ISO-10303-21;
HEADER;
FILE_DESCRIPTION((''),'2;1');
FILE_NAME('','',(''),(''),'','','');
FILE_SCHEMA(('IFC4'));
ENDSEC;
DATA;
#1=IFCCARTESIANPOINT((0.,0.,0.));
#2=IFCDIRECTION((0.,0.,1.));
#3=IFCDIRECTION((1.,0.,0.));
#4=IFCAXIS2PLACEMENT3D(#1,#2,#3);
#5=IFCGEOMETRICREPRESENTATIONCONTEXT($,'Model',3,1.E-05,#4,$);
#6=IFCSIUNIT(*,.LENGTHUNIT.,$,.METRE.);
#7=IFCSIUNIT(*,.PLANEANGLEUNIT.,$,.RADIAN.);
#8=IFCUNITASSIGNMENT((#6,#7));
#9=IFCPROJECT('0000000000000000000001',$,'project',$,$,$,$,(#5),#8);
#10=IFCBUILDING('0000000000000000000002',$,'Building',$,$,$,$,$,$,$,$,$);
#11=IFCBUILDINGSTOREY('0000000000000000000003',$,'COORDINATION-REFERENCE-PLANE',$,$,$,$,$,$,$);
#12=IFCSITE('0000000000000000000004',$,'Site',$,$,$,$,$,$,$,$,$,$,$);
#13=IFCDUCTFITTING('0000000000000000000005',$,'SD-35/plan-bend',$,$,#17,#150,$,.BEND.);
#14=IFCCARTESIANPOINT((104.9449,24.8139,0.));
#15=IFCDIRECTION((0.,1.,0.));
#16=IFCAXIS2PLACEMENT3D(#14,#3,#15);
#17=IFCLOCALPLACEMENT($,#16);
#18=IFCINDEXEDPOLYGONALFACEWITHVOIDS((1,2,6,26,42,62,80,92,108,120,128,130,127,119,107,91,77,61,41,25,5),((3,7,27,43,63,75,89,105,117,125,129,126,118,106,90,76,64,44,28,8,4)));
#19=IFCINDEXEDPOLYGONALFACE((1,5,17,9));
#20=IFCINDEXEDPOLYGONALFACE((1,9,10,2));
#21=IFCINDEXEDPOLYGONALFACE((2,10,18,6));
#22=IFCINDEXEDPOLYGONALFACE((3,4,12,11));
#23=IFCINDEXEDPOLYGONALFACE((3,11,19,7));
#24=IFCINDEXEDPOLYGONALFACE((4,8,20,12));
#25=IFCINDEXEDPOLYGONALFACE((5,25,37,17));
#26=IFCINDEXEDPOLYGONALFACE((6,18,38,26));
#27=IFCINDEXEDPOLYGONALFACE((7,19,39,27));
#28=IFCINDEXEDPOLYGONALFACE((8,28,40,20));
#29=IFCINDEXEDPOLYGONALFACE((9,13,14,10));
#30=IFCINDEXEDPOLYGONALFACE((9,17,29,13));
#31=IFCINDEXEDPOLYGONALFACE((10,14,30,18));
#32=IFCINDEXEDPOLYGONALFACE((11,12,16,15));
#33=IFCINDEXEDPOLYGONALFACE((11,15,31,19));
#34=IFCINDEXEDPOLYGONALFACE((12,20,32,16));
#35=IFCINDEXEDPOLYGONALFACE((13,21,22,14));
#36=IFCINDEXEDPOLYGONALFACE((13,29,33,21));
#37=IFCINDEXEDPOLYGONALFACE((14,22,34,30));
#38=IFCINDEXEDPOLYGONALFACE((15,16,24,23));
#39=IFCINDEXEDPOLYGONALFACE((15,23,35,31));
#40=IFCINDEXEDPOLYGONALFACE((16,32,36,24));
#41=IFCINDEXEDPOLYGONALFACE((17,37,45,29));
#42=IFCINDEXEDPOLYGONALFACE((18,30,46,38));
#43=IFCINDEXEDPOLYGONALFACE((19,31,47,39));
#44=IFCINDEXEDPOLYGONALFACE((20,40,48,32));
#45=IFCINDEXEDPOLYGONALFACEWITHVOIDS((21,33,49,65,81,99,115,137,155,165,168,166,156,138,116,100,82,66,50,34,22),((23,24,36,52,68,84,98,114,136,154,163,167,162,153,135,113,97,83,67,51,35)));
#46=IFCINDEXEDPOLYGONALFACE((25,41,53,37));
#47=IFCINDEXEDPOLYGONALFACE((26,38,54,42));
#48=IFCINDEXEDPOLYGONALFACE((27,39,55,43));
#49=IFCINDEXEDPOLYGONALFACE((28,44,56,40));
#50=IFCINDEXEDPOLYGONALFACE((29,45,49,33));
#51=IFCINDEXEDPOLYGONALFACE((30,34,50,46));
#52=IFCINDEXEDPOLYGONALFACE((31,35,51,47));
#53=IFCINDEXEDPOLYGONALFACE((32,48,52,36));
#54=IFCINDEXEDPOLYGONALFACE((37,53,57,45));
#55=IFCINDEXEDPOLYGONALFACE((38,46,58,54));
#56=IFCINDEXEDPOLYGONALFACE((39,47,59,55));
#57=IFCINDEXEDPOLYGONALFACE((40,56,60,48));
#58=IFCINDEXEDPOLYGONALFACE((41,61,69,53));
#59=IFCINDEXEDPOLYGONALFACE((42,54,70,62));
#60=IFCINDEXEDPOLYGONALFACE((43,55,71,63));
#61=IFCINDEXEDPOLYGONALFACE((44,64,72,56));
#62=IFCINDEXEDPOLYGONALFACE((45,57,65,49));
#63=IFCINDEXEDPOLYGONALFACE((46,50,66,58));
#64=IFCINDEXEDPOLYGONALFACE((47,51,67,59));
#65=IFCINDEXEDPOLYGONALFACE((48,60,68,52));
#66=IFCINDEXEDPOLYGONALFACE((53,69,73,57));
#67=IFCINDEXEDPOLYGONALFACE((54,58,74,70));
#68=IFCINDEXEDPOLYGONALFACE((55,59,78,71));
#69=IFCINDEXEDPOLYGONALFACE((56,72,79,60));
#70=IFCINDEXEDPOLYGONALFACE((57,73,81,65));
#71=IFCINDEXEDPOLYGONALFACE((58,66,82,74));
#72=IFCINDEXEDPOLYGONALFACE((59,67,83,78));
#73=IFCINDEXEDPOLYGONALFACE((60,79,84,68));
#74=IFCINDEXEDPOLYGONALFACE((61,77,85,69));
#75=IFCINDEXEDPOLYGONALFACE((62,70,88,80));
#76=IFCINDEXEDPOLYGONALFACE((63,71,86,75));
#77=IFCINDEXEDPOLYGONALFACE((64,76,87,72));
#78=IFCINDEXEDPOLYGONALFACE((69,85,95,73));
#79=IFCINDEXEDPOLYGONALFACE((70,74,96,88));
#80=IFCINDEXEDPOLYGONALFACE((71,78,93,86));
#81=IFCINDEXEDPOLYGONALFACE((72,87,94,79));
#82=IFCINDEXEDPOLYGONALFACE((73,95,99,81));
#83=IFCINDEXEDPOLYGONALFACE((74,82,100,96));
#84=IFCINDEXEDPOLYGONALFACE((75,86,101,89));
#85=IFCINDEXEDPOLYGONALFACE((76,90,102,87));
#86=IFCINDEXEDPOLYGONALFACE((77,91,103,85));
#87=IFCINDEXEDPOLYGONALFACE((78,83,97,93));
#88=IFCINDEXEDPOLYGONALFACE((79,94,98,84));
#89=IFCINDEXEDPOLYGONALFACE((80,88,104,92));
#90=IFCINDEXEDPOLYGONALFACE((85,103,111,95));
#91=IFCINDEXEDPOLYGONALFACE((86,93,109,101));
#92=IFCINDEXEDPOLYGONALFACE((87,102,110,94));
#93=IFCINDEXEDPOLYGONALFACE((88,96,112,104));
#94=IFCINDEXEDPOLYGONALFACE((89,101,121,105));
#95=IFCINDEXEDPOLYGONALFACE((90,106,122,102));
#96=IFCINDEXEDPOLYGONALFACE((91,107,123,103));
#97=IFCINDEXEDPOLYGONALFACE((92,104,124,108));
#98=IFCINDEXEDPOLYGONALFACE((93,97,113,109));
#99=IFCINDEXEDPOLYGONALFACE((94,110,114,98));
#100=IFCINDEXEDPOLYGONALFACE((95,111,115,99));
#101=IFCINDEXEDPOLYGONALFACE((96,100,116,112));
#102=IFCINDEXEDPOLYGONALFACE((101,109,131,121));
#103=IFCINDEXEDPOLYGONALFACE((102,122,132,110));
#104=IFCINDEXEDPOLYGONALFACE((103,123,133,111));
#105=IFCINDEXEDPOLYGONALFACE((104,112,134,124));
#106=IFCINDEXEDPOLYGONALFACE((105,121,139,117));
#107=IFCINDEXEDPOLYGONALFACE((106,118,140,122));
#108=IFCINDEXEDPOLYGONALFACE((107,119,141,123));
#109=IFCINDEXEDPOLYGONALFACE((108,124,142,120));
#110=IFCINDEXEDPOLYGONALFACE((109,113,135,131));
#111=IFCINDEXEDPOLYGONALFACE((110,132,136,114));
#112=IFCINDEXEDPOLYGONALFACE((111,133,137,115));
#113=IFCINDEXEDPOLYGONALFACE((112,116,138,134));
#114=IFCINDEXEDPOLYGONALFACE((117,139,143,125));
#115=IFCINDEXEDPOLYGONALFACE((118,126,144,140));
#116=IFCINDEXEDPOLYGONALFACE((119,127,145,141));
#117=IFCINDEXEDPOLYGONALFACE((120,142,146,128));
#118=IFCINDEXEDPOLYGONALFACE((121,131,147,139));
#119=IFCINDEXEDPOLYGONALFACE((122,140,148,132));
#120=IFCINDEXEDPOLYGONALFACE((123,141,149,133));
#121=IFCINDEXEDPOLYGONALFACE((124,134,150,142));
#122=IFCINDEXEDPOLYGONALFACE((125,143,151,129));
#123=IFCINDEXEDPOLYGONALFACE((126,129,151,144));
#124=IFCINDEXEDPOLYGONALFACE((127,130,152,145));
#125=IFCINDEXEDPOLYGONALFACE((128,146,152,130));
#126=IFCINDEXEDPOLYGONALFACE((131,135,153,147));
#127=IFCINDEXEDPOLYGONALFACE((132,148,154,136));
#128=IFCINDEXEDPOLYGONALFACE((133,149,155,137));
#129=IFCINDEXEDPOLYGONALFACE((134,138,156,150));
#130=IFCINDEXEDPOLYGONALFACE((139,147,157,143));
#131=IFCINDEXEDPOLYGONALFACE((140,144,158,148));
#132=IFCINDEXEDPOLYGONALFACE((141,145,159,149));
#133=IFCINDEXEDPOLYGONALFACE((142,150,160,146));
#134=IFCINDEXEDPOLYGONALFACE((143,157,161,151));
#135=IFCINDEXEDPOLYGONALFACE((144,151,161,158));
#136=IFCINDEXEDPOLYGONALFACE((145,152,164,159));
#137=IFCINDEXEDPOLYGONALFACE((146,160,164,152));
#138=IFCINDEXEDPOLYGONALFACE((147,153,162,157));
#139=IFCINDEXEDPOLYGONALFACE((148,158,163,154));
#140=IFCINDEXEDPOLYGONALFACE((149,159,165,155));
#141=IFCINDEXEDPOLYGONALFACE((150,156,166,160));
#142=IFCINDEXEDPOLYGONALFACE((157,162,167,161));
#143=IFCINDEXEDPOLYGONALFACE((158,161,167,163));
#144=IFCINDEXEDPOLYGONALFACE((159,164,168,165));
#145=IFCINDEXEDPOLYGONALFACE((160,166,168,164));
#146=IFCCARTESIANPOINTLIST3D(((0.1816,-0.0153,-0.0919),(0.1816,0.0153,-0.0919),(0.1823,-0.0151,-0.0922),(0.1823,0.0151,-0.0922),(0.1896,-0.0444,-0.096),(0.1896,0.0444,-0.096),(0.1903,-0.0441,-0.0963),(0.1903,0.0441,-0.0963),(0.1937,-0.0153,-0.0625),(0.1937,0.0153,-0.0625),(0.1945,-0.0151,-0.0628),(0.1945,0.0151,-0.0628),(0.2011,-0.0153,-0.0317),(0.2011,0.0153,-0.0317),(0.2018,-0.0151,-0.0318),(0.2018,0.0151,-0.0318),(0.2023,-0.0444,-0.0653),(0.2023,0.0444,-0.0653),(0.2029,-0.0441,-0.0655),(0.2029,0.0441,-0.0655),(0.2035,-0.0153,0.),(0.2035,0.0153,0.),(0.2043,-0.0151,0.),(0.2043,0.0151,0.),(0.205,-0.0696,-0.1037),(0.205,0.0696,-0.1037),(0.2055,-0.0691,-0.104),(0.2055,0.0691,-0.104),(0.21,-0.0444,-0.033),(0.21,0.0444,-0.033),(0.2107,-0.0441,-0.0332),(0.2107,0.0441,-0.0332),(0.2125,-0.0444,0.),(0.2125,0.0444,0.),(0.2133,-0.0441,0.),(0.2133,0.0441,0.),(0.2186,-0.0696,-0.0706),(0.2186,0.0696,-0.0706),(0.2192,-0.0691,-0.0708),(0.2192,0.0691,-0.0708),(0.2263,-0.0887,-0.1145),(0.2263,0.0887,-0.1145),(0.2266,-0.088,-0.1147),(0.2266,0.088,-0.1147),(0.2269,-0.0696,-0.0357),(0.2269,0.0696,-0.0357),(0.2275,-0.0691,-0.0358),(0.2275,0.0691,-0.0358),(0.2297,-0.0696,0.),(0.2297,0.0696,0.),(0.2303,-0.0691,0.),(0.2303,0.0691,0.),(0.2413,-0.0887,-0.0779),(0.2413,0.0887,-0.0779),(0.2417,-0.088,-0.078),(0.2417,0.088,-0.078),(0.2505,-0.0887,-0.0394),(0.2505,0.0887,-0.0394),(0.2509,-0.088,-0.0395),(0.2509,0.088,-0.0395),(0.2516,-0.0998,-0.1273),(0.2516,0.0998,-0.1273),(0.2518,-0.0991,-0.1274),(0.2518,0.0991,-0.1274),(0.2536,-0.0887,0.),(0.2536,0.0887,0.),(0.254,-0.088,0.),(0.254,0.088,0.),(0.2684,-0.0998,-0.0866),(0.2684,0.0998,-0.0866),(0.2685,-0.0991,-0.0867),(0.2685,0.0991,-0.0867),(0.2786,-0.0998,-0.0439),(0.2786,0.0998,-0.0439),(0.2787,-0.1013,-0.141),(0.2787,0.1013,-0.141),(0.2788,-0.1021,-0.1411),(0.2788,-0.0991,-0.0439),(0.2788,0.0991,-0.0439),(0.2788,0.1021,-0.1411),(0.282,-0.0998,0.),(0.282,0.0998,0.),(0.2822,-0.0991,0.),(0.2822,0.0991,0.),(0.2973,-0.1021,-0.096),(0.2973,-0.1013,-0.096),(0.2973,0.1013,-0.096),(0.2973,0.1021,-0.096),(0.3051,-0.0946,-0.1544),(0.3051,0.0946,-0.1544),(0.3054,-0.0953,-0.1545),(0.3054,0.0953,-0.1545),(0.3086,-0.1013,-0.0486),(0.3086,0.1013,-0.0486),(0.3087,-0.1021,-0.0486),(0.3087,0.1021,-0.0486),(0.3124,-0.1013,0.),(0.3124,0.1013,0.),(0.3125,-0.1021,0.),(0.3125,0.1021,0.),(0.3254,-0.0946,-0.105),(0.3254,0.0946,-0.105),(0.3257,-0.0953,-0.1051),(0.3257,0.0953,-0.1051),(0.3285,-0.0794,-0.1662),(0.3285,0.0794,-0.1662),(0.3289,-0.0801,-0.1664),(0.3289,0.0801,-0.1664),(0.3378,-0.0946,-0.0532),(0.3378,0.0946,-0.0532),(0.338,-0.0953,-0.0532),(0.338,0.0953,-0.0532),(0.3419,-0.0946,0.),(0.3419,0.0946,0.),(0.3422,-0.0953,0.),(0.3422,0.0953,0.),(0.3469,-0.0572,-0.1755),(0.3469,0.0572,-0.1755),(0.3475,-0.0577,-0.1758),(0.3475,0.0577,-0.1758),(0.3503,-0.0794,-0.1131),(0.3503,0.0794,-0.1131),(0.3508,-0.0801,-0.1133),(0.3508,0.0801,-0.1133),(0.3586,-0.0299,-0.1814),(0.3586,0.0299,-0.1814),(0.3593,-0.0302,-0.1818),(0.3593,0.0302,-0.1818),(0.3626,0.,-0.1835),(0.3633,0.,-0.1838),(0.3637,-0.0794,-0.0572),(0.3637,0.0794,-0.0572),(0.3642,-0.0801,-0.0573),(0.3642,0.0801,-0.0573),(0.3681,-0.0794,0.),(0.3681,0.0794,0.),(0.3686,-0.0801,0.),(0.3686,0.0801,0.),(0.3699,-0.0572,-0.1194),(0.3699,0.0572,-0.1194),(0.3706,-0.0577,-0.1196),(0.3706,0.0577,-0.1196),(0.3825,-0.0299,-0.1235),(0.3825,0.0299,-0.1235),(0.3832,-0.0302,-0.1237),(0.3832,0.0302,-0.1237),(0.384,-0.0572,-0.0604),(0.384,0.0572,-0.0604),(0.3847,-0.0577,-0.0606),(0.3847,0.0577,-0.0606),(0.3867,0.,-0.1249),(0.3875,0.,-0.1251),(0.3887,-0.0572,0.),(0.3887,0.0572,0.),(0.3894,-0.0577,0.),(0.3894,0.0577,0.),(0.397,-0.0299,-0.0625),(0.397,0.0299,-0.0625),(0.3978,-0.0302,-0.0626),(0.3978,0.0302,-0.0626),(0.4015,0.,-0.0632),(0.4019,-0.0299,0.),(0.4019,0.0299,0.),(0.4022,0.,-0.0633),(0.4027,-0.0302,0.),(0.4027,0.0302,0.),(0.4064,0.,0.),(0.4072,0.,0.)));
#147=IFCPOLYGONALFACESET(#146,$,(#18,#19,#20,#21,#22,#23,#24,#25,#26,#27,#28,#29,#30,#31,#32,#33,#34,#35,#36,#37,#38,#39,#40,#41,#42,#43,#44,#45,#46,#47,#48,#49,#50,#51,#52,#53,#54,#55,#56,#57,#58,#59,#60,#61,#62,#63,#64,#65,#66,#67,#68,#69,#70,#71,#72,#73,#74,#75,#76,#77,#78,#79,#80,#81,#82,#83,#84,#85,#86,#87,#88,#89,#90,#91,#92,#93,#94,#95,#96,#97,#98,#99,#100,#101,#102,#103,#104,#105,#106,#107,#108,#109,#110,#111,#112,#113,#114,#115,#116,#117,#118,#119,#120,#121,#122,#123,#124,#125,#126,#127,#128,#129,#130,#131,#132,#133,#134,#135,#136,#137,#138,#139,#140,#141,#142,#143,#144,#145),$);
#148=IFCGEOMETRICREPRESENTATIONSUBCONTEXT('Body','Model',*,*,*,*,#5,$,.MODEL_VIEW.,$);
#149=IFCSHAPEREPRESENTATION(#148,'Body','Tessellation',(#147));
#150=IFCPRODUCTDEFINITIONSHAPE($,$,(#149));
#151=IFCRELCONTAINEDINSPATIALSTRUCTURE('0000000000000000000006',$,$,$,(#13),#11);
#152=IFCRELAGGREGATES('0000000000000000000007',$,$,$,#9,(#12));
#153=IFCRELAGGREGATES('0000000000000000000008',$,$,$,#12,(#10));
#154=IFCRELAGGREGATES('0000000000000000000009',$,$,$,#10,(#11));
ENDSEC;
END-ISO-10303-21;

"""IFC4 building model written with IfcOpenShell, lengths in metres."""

from ifc_helpers import new_model, entity, si_unit, frame, origin_with_axes, place, context, subcontext, project, spatial, element, save


model = new_model("IFC4")

# Units and contexts
model_context = context("Model", 3, precision=1e-05, world=origin_with_axes())
body_context_1 = subcontext(model_context, "Body", "Model", "MODEL_VIEW")
ifc_project = project(units=[si_unit("LENGTHUNIT", "METRE"), si_unit("PLANEANGLEUNIT", "RADIAN")], contexts=[model_context])

# Site, building, storey
site = spatial("IfcSite", under=ifc_project, Name="Site")
building = spatial("IfcBuilding", under=site, Name="Building")
storey = spatial("IfcBuildingStorey", under=building, Name="COORDINATION-REFERENCE-PLANE")

# Duct fitting
duct_fitting_1_placement = place(None, frame((104.9449, 24.8139, 0.0), z_axis=(1.0, 0.0, 0.0), x_axis=(0.0, 1.0, 0.0)))
element("IfcDuctFitting", 1, at=duct_fitting_1_placement, inside=storey, Name="SD-35/plan-bend", PredefinedType="BEND", context=body_context_1, shape_type="SweptSolid", body=[
    entity("IfcRevolvedAreaSolid", entity("IfcCircleHollowProfileDef", "AREA", None, entity("IfcAxis2Placement2D", entity("IfcCartesianPoint", [0.3048, 0.0])), 0.1024, 0.0008), entity("IfcAxis2Placement3D", entity("IfcCartesianPoint", [0.0, 0.0, 0.0]), entity("IfcDirection", [0.0, 0.0, 1.0]), entity("IfcDirection", [1.0, 0.0, 0.0])), entity("IfcAxis1Placement", entity("IfcCartesianPoint", [0.0, 0.0, 0.0]), entity("IfcDirection", [0.0, 1.0, 0.0])), 0.468399),
])

save(model, "model.ifc")
